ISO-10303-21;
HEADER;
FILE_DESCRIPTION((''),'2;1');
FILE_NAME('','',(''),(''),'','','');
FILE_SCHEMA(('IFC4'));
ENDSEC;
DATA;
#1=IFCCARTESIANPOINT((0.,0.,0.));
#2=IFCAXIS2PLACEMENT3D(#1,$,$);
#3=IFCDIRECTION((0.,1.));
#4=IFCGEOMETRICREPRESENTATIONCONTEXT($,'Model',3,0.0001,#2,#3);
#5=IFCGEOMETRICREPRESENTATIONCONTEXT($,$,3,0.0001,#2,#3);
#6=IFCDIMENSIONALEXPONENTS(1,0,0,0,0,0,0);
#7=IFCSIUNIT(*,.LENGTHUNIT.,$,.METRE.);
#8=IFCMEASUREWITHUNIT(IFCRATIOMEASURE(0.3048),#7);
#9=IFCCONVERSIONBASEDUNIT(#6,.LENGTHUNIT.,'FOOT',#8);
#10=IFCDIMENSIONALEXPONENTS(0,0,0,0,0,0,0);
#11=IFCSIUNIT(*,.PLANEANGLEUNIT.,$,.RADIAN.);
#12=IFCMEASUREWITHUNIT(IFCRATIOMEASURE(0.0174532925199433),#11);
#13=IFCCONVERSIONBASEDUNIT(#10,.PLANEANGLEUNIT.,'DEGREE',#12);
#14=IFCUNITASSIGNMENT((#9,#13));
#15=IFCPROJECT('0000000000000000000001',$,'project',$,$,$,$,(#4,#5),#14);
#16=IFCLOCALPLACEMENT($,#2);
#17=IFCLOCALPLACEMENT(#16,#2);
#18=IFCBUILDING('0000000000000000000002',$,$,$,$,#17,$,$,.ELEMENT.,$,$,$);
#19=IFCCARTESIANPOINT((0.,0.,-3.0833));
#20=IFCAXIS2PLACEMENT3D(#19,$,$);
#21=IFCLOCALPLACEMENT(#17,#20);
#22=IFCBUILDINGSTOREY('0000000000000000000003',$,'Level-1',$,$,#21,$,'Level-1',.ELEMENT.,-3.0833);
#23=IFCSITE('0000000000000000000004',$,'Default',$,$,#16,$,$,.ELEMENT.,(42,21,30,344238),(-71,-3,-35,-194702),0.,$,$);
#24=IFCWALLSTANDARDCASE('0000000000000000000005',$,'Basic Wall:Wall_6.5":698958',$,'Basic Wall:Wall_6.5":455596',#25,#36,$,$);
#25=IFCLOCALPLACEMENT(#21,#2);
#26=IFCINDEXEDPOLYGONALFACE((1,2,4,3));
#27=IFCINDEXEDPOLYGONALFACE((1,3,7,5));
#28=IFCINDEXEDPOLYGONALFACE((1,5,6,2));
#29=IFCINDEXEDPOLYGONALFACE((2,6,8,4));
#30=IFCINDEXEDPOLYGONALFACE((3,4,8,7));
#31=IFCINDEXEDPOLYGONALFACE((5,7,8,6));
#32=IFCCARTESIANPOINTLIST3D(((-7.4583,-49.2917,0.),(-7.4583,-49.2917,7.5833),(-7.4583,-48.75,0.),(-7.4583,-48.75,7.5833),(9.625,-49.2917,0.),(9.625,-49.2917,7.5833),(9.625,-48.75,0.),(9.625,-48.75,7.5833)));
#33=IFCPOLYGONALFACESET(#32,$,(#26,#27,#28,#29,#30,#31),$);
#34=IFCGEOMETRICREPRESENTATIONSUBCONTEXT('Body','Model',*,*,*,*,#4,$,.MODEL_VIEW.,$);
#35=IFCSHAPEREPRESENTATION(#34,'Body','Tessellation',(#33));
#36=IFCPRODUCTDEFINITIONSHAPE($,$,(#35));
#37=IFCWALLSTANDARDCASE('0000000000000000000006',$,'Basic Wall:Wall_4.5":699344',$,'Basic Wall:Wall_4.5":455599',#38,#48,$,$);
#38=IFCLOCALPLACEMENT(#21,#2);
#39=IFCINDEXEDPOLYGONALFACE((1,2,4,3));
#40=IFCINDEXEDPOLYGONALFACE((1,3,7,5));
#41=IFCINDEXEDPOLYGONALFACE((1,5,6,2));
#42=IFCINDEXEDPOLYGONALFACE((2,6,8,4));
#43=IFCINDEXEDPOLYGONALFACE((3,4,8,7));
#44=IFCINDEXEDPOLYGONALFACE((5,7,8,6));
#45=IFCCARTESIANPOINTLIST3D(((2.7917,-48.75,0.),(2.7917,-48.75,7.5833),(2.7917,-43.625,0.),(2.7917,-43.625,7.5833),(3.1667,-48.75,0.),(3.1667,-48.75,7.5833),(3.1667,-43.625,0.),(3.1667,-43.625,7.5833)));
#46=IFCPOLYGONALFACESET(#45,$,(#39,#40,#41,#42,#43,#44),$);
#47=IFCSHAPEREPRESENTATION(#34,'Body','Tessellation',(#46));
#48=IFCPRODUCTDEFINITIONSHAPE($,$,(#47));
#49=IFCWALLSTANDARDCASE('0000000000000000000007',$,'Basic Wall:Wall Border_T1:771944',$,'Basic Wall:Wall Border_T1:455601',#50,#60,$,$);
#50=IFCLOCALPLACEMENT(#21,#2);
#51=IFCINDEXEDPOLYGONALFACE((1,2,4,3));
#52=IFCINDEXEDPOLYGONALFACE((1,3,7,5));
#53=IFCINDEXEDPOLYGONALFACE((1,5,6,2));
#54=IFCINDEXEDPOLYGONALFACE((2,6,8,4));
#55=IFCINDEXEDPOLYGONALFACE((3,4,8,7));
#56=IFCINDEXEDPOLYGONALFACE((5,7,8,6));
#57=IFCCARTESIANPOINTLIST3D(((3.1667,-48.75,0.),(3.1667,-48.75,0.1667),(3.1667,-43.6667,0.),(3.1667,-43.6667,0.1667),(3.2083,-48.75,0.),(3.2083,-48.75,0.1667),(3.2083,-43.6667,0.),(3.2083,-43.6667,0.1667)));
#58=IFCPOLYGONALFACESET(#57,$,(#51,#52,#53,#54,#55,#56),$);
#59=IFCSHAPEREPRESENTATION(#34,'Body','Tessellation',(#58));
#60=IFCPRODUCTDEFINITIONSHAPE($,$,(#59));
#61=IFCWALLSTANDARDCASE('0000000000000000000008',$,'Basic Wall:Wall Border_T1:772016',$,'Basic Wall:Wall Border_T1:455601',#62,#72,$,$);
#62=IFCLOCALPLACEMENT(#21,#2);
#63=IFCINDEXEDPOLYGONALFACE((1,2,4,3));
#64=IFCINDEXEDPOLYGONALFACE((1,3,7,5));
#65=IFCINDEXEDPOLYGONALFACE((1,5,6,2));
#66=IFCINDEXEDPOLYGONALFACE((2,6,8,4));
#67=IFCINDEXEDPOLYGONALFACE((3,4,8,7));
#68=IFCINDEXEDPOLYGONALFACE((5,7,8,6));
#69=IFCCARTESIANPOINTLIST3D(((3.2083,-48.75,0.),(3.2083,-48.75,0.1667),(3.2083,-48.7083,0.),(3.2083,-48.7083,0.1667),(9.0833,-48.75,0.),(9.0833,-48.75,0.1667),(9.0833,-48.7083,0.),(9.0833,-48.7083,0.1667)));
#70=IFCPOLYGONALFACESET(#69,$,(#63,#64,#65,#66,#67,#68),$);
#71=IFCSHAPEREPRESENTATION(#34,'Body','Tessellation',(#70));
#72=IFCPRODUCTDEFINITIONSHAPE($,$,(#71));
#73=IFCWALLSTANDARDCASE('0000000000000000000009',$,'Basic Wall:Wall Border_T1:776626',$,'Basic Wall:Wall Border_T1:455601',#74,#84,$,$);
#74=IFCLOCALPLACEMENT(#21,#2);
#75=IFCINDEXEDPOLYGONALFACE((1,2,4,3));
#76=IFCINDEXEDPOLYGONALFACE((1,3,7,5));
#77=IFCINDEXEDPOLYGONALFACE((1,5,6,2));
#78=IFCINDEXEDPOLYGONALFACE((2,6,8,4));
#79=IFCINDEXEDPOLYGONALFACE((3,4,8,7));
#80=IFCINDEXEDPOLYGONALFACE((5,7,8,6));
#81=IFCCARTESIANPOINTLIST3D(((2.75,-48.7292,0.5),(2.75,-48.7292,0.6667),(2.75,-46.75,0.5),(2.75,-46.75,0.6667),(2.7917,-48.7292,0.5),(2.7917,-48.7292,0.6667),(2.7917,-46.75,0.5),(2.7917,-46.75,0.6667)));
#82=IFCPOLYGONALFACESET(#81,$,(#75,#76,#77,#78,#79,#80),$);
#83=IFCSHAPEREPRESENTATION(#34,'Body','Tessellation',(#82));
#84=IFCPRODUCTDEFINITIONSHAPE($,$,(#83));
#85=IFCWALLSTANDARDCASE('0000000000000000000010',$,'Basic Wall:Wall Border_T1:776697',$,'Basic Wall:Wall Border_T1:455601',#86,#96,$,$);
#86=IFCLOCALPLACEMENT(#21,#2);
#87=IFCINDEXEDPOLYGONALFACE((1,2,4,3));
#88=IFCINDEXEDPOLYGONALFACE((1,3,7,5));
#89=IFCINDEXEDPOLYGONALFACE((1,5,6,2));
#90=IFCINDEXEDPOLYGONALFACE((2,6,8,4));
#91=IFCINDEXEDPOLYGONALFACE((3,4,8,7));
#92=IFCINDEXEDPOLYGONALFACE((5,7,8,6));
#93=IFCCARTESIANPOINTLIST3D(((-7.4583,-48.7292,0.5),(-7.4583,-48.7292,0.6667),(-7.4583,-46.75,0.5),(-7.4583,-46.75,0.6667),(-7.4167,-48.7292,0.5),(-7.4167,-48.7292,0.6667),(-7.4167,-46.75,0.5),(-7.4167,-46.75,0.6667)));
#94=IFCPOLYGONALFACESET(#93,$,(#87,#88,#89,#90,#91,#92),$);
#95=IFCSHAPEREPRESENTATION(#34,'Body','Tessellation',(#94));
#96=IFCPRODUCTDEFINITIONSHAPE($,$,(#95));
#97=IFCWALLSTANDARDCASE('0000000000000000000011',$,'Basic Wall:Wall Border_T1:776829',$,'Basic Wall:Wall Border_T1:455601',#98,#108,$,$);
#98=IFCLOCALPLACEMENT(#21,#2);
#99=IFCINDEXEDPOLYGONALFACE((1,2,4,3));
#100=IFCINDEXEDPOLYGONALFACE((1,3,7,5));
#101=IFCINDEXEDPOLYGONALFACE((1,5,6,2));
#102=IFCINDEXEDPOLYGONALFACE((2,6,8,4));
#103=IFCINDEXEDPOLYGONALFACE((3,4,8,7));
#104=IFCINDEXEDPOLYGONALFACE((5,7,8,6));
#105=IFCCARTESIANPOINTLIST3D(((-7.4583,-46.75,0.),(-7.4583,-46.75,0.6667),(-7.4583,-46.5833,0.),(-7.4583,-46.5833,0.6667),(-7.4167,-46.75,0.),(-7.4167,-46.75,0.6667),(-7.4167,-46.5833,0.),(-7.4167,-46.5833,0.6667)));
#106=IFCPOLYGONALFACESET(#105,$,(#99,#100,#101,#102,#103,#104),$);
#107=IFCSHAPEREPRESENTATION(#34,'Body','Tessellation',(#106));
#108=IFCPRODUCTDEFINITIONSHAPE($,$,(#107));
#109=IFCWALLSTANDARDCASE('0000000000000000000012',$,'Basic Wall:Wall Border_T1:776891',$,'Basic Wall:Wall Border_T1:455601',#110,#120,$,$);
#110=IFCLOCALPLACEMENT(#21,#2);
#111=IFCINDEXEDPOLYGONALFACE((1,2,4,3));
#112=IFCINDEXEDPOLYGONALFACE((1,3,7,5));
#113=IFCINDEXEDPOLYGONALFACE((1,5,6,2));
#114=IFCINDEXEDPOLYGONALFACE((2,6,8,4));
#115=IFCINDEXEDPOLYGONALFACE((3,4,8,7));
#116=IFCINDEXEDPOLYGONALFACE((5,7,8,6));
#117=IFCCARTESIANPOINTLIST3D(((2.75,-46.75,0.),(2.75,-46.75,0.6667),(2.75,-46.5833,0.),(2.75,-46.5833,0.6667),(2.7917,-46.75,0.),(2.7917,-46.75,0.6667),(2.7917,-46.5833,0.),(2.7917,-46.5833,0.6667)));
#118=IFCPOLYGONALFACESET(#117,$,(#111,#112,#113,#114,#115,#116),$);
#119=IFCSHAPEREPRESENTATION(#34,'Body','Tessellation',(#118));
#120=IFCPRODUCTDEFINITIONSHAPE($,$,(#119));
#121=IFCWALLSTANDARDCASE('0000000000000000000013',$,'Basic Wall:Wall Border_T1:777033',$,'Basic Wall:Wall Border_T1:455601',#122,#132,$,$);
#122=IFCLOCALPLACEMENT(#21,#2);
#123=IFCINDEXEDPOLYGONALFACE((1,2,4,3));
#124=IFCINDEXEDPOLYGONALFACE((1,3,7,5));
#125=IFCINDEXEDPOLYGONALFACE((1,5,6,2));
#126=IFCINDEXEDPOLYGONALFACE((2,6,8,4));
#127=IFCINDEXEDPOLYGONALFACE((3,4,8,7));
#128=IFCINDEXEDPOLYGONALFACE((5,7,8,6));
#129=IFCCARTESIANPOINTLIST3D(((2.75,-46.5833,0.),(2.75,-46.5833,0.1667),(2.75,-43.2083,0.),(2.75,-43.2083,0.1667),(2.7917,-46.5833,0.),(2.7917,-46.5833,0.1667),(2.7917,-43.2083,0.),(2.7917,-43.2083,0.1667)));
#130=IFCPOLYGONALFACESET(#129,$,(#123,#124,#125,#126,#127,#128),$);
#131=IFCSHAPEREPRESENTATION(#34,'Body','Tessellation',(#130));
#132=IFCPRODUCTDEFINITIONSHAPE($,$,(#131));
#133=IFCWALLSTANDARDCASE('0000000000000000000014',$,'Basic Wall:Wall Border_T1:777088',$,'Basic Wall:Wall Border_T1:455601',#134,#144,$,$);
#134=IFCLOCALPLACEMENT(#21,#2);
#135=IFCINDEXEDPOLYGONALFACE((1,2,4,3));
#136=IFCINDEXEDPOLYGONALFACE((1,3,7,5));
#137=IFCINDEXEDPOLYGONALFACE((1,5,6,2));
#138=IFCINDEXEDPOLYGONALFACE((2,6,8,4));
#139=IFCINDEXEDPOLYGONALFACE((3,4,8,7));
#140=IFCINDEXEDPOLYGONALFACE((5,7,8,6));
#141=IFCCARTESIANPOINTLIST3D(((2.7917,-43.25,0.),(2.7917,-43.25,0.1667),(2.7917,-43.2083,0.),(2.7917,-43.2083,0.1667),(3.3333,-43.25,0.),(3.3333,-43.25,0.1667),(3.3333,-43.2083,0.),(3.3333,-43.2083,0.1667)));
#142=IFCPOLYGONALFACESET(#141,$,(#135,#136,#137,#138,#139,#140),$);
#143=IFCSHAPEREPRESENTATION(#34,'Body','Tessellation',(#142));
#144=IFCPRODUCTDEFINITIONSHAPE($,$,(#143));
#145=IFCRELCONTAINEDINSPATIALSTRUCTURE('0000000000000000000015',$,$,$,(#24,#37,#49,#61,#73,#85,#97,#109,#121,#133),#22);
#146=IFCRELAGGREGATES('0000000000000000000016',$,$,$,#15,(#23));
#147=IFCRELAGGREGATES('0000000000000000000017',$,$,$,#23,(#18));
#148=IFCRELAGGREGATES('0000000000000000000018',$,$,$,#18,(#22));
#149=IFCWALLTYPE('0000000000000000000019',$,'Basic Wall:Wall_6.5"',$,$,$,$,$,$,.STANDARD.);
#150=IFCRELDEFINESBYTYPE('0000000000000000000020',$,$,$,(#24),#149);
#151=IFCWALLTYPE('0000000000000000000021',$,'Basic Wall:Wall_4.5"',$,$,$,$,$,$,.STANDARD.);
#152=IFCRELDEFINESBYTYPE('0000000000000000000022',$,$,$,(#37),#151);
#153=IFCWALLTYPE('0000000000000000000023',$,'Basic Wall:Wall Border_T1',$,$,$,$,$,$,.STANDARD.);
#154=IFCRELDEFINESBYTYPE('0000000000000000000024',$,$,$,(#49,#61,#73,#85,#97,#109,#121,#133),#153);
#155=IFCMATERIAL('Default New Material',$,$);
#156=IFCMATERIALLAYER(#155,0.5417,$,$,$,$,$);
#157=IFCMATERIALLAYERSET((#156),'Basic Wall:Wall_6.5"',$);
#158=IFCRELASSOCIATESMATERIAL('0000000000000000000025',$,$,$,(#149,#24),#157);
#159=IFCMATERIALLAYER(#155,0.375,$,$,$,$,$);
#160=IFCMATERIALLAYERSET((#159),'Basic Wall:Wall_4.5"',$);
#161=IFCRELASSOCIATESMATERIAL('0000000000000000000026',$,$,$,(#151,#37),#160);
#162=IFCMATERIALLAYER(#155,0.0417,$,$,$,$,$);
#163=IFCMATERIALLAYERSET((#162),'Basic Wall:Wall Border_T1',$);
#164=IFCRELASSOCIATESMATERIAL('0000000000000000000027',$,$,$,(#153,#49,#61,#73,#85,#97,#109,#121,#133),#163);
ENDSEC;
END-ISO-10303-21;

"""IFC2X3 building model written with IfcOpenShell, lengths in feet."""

from ifc_helpers import new_model, entity, si_unit, converted_unit, direction, frame, frame_2d, origin, place, context, subcontext, project, spatial, rectangle, extrude, material, layer, layer_set, layer_usage, type_object, element, save


model = new_model("IFC2X3")

# Units and contexts
model_context = context("Model", 3, precision=0.0001, world=origin(), true_north=direction((0.0, 1.0)))
context_of_model = context(None, 3, precision=0.0001, world=origin(), true_north=direction((0.0, 1.0)))
body_context = subcontext(model_context, "Body", "Model", "MODEL_VIEW")
ifc_project = project(units=[converted_unit("LENGTHUNIT", "FOOT", entity("IfcRatioMeasure", 0.3048), si_unit("LENGTHUNIT", "METRE"), dimensions=[1, 0, 0, 0, 0, 0, 0]), converted_unit("PLANEANGLEUNIT", "DEGREE", entity("IfcRatioMeasure", 0.0174532925199433), si_unit("PLANEANGLEUNIT", "RADIAN"), dimensions=[0, 0, 0, 0, 0, 0, 0])], contexts=[model_context, context_of_model])

# Site, building, storey
site_placement = place(None, origin())
site = spatial("IfcSite", under=ifc_project, at=site_placement, Name="Default", CompositionType="ELEMENT", RefLatitude=(42, 21, 30, 344238), RefLongitude=(-71, -3, -35, -194702), RefElevation=0.0)
building_placement = place(site_placement, origin())
building = spatial("IfcBuilding", under=site, at=building_placement, CompositionType="ELEMENT")
storey_placement = place(building_placement, frame((0.0, 0.0, -3.0833)))
storey = spatial("IfcBuildingStorey", under=building, at=storey_placement, Name="Level-1", LongName="Level-1", CompositionType="ELEMENT", Elevation=-3.0833)

# Walls
ifc_material = material(Name="Default New Material")
ifc_layer_1 = layer(ifc_material, 0.5417)
ifc_layer_set_1 = layer_set([ifc_layer_1], Name="Basic Wall:Wall_6.5\"")
ifc_layer_usage_1 = layer_usage(ifc_layer_set_1, "AXIS2", "NEGATIVE", 0.2708)
wall_type_1 = type_object("IfcWallType", Name="Basic Wall:Wall_6.5\"", PredefinedType="STANDARD", material=ifc_layer_set_1)
wall_1_placement = place(storey_placement, frame((-7.4583, -49.0208, 0.0)))
element("IfcWallStandardCase", 1, at=wall_1_placement, inside=storey, type_object=wall_type_1, material=ifc_layer_usage_1, Name="Basic Wall:Wall_6.5\":698958", ObjectType="Basic Wall:Wall_6.5\":455596", context=body_context, shape_type="SweptSolid", body=[
    extrude(rectangle(XDim=17.0833, YDim=0.5417, at=frame_2d((8.5417, 0.0), x_axis=(-1.0, 0.0))), origin(), (0.0, 0.0, 1.0), 7.5833),
])
ifc_layer_2 = layer(ifc_material, 0.375)
ifc_layer_set_2 = layer_set([ifc_layer_2], Name="Basic Wall:Wall_4.5\"")
ifc_layer_usage_2 = layer_usage(ifc_layer_set_2, "AXIS2", "NEGATIVE", 0.1875)
wall_type_2 = type_object("IfcWallType", Name="Basic Wall:Wall_4.5\"", PredefinedType="STANDARD", material=ifc_layer_set_2)
wall_2_placement = place(storey_placement, frame((2.9792, -43.625, 0.0), z_axis=(0.0, 0.0, 1.0), x_axis=(0.0, -1.0, 0.0)))
element("IfcWallStandardCase", 2, at=wall_2_placement, inside=storey, type_object=wall_type_2, material=ifc_layer_usage_2, Name="Basic Wall:Wall_4.5\":699344", ObjectType="Basic Wall:Wall_4.5\":455599", context=body_context, shape_type="SweptSolid", body=[
    extrude(rectangle(XDim=5.125, YDim=0.375, at=frame_2d((2.5625, 0.0), x_axis=(-1.0, 0.0))), origin(), (0.0, 0.0, 1.0), 7.5833),
])
ifc_layer_3 = layer(ifc_material, 0.0417)
ifc_layer_set_3 = layer_set([ifc_layer_3], Name="Basic Wall:Wall Border_T1")
ifc_layer_usage_3 = layer_usage(ifc_layer_set_3, "AXIS2", "NEGATIVE", 0.0208)
wall_type_3 = type_object("IfcWallType", Name="Basic Wall:Wall Border_T1", PredefinedType="STANDARD", material=ifc_layer_set_3)
wall_3_placement = place(storey_placement, frame((3.1875, -43.6667, 0.0), z_axis=(0.0, 0.0, 1.0), x_axis=(0.0, -1.0, 0.0)))
element("IfcWallStandardCase", 3, at=wall_3_placement, inside=storey, type_object=wall_type_3, material=ifc_layer_usage_3, Name="Basic Wall:Wall Border_T1:771944", ObjectType="Basic Wall:Wall Border_T1:455601", context=body_context, shape_type="SweptSolid", body=[
    extrude(rectangle(XDim=5.0833, YDim=0.0417, at=frame_2d((2.5417, 0.0), x_axis=(-1.0, 0.0))), origin(), (0.0, 0.0, 1.0), 0.1667),
])
ifc_layer_usage_4 = layer_usage(ifc_layer_set_3, "AXIS2", "NEGATIVE", 0.0208)
wall_4_placement = place(storey_placement, frame((3.2083, -48.7292, 0.0)))
element("IfcWallStandardCase", 4, at=wall_4_placement, inside=storey, type_object=wall_type_3, material=ifc_layer_usage_4, Name="Basic Wall:Wall Border_T1:772016", ObjectType="Basic Wall:Wall Border_T1:455601", context=body_context, shape_type="SweptSolid", body=[
    extrude(rectangle(XDim=5.875, YDim=0.0417, at=frame_2d((2.9375, 0.0), x_axis=(-1.0, 0.0))), origin(), (0.0, 0.0, 1.0), 0.1667),
])
ifc_layer_usage_5 = layer_usage(ifc_layer_set_3, "AXIS2", "NEGATIVE", 0.0208)
wall_5_placement = place(storey_placement, frame((2.7708, -48.7292, 0.5), z_axis=(0.0, 0.0, 1.0), x_axis=(0.0, 1.0, 0.0)))
element("IfcWallStandardCase", 5, at=wall_5_placement, inside=storey, type_object=wall_type_3, material=ifc_layer_usage_5, Name="Basic Wall:Wall Border_T1:776626", ObjectType="Basic Wall:Wall Border_T1:455601", context=body_context, shape_type="SweptSolid", body=[
    extrude(rectangle(XDim=1.9792, YDim=0.0417, at=frame_2d((0.9896, 0.0), x_axis=(-1.0, 0.0))), origin(), (0.0, 0.0, 1.0), 0.1667),
])
ifc_layer_usage_6 = layer_usage(ifc_layer_set_3, "AXIS2", "POSITIVE", -0.0208)
wall_6_placement = place(storey_placement, frame((-7.4375, -48.7292, 0.5), z_axis=(0.0, 0.0, 1.0), x_axis=(0.0, 1.0, 0.0)))
element("IfcWallStandardCase", 6, at=wall_6_placement, inside=storey, type_object=wall_type_3, material=ifc_layer_usage_6, Name="Basic Wall:Wall Border_T1:776697", ObjectType="Basic Wall:Wall Border_T1:455601", context=body_context, shape_type="SweptSolid", body=[
    extrude(rectangle(XDim=1.9792, YDim=0.0417, at=frame_2d((0.9896, 0.0), x_axis=(-1.0, 0.0))), origin(), (0.0, 0.0, 1.0), 0.1667),
])
ifc_layer_usage_7 = layer_usage(ifc_layer_set_3, "AXIS2", "POSITIVE", -0.0208)
wall_7_placement = place(storey_placement, frame((-7.4375, -46.75, 0.0), z_axis=(0.0, 0.0, 1.0), x_axis=(0.0, 1.0, 0.0)))
element("IfcWallStandardCase", 7, at=wall_7_placement, inside=storey, type_object=wall_type_3, material=ifc_layer_usage_7, Name="Basic Wall:Wall Border_T1:776829", ObjectType="Basic Wall:Wall Border_T1:455601", context=body_context, shape_type="SweptSolid", body=[
    extrude(rectangle(XDim=0.1667, YDim=0.0417, at=frame_2d((0.0833, 0.0), x_axis=(-1.0, 0.0))), origin(), (0.0, 0.0, 1.0), 0.6667),
])
ifc_layer_usage_8 = layer_usage(ifc_layer_set_3, "AXIS2", "NEGATIVE", 0.0208)
wall_8_placement = place(storey_placement, frame((2.7708, -46.75, 0.0), z_axis=(0.0, 0.0, 1.0), x_axis=(0.0, 1.0, 0.0)))
element("IfcWallStandardCase", 8, at=wall_8_placement, inside=storey, type_object=wall_type_3, material=ifc_layer_usage_8, Name="Basic Wall:Wall Border_T1:776891", ObjectType="Basic Wall:Wall Border_T1:455601", context=body_context, shape_type="SweptSolid", body=[
    extrude(rectangle(XDim=0.1667, YDim=0.0417, at=frame_2d((0.0833, 0.0), x_axis=(-1.0, 0.0))), origin(), (0.0, 0.0, 1.0), 0.6667),
])
ifc_layer_usage_9 = layer_usage(ifc_layer_set_3, "AXIS2", "NEGATIVE", 0.0208)
wall_9_placement = place(storey_placement, frame((2.7708, -46.5833, 0.0), z_axis=(0.0, 0.0, 1.0), x_axis=(0.0, 1.0, 0.0)))
element("IfcWallStandardCase", 9, at=wall_9_placement, inside=storey, type_object=wall_type_3, material=ifc_layer_usage_9, Name="Basic Wall:Wall Border_T1:777033", ObjectType="Basic Wall:Wall Border_T1:455601", context=body_context, shape_type="SweptSolid", body=[
    extrude(rectangle(XDim=3.375, YDim=0.0417, at=frame_2d((1.6875, 0.0), x_axis=(-1.0, 0.0))), origin(), (0.0, 0.0, 1.0), 0.1667),
])
ifc_layer_usage_10 = layer_usage(ifc_layer_set_3, "AXIS2", "NEGATIVE", 0.0208)
wall_10_placement = place(storey_placement, frame((2.7917, -43.2292, 0.0)))
element("IfcWallStandardCase", 10, at=wall_10_placement, inside=storey, type_object=wall_type_3, material=ifc_layer_usage_10, Name="Basic Wall:Wall Border_T1:777088", ObjectType="Basic Wall:Wall Border_T1:455601", context=body_context, shape_type="SweptSolid", body=[
    extrude(rectangle(XDim=0.5417, YDim=0.0417, at=frame_2d((0.2708, 0.0), x_axis=(-1.0, 0.0))), origin(), (0.0, 0.0, 1.0), 0.1667),
])

save(model, "model.ifc")
